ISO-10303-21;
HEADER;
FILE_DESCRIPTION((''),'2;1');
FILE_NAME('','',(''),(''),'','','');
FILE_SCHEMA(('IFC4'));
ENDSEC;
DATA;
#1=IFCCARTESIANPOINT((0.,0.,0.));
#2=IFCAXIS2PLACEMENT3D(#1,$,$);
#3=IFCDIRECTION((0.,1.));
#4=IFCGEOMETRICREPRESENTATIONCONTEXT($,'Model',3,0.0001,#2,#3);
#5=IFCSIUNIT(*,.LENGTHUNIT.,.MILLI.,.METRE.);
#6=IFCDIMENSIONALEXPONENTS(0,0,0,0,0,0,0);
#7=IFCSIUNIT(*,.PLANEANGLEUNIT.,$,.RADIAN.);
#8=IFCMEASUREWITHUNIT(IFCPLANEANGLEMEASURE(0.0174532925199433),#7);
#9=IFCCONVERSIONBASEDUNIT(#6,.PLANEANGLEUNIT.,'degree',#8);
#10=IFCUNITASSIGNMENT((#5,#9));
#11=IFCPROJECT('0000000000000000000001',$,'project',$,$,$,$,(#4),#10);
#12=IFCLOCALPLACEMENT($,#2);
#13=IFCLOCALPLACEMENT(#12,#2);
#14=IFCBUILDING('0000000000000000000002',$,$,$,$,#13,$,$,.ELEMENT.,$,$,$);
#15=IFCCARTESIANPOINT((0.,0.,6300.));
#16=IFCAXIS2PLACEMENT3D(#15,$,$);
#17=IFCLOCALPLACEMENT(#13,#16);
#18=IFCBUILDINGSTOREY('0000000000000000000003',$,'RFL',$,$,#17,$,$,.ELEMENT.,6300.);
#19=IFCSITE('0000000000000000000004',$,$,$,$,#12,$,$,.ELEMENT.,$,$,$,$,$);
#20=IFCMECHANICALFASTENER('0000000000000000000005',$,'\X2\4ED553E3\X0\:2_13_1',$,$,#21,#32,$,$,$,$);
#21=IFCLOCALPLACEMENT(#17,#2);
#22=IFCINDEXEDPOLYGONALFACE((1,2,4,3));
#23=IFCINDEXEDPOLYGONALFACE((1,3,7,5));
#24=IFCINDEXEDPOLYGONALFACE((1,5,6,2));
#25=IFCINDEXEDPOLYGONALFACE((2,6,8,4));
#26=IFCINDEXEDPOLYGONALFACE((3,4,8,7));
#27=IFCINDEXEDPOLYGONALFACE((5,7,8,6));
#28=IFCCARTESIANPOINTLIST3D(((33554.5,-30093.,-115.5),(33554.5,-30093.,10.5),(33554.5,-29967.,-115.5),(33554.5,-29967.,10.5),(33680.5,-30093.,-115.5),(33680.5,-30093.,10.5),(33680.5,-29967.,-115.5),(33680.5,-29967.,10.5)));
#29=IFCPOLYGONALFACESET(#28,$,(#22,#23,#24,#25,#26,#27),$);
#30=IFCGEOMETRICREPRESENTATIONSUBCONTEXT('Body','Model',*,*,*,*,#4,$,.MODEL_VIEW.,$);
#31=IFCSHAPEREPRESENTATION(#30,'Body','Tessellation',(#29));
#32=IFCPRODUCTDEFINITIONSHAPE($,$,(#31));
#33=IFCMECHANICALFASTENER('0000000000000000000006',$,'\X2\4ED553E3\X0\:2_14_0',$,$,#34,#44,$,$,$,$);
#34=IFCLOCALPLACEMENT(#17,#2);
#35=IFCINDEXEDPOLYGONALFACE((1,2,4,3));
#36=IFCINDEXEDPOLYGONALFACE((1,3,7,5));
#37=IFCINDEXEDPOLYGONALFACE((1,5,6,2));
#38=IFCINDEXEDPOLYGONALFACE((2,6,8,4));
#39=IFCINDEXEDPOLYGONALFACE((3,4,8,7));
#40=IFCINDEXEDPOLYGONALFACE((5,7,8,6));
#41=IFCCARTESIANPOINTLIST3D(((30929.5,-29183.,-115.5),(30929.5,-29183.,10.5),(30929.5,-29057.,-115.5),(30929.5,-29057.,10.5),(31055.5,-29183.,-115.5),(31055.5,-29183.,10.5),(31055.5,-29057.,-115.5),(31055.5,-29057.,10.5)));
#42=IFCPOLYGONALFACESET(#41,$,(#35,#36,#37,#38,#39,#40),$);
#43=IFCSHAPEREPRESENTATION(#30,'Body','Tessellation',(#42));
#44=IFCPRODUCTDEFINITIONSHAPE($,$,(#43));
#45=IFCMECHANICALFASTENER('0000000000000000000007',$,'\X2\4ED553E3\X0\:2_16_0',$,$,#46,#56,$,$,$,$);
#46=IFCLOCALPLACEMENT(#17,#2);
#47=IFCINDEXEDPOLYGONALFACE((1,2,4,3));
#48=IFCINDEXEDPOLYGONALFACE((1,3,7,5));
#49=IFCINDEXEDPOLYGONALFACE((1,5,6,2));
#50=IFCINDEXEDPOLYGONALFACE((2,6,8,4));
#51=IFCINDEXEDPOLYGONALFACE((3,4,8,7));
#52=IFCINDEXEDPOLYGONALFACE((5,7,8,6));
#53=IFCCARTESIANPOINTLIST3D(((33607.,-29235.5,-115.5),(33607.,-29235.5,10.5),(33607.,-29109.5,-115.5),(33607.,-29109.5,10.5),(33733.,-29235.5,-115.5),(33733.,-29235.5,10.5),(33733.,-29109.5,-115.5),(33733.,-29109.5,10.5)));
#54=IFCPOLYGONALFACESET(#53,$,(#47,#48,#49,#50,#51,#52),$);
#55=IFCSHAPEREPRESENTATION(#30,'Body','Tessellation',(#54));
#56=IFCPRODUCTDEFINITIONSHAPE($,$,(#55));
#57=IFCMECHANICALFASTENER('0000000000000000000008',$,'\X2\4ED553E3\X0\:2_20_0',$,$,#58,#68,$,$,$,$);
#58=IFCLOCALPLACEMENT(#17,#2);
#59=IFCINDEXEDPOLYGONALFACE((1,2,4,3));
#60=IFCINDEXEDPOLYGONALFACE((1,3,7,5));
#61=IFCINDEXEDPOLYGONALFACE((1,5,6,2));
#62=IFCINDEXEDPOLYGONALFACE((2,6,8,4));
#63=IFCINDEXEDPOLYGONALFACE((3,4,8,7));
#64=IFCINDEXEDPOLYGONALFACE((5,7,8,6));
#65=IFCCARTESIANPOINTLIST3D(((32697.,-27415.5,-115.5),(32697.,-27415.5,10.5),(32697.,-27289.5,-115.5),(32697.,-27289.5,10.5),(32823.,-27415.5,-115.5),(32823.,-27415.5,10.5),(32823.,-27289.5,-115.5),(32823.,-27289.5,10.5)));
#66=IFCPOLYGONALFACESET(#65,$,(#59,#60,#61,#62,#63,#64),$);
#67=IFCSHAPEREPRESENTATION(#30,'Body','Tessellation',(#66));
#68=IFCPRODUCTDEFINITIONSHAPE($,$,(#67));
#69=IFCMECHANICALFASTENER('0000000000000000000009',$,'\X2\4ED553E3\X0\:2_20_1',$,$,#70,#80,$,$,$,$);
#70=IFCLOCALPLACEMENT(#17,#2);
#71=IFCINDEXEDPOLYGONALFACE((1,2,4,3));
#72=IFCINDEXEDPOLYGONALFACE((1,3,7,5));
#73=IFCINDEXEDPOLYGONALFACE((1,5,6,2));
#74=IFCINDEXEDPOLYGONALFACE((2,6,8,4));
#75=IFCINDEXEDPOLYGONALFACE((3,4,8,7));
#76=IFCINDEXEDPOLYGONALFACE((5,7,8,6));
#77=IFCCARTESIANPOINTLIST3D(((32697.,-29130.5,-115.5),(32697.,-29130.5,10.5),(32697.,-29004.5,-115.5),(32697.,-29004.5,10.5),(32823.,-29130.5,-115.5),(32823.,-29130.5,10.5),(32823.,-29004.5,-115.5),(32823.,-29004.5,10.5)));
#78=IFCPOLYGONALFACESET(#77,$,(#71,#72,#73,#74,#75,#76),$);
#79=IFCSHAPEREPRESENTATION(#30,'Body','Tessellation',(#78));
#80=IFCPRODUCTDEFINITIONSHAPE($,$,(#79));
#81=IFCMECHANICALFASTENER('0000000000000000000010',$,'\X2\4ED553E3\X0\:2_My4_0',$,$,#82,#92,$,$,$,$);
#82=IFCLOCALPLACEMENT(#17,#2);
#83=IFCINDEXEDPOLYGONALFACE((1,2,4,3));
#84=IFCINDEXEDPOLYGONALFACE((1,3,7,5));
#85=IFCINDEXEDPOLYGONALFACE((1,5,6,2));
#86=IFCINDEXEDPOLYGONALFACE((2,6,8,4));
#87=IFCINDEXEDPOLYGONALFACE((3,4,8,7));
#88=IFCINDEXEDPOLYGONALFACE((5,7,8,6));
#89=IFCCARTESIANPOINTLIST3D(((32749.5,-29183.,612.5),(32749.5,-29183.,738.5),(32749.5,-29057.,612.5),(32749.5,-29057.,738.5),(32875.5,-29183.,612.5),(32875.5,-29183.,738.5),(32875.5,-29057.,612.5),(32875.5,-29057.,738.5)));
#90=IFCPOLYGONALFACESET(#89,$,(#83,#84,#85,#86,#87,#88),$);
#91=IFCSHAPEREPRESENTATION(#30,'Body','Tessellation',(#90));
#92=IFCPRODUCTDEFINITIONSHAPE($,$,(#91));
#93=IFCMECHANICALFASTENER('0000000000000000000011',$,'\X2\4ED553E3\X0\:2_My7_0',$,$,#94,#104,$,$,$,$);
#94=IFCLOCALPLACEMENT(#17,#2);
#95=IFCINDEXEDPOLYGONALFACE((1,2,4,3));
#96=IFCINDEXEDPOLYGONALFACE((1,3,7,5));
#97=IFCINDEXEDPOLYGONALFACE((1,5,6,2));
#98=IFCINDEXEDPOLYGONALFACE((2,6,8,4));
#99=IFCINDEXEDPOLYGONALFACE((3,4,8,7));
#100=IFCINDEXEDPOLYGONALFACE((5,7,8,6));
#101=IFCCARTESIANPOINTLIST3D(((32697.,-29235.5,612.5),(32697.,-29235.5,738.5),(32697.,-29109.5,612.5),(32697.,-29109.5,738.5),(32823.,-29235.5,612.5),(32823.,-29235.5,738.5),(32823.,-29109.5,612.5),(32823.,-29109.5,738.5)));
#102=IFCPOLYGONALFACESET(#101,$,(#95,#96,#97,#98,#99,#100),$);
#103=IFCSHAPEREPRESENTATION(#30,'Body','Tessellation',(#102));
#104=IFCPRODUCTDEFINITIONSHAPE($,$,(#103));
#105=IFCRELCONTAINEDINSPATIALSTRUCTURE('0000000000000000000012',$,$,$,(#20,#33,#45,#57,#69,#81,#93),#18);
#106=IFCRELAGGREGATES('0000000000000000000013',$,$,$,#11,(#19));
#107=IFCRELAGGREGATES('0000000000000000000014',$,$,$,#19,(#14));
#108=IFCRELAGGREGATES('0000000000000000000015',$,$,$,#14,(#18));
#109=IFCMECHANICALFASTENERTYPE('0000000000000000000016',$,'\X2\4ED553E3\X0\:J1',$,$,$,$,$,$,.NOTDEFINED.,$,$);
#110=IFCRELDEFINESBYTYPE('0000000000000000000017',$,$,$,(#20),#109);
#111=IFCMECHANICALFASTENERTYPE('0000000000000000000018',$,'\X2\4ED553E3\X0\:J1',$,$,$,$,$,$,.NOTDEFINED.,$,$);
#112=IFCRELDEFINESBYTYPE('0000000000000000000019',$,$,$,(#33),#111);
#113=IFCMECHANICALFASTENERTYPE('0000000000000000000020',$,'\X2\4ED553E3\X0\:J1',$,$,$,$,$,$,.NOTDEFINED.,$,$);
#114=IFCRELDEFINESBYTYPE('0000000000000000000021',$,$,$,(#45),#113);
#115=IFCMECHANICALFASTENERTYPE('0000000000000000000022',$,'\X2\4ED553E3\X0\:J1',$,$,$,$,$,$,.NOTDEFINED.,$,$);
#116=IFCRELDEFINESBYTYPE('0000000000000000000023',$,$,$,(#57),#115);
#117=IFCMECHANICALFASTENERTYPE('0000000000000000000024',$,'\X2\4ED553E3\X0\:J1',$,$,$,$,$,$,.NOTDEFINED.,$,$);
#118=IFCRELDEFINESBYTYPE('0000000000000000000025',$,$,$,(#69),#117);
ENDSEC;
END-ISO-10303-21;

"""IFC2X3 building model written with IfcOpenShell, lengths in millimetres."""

from ifc_helpers import new_model, entity, si_unit, converted_unit, direction, frame, origin, origin_with_axes, origin_2d, place, context, subcontext, project, spatial, rectangle, extrude, type_object, element, save


model = new_model("IFC2X3")

# Units and contexts
model_context = context("Model", 3, precision=0.0001, world=origin(), true_north=direction((0.0, 1.0)))
body_context = subcontext(model_context, "Body", "Model", "MODEL_VIEW")
ifc_project = project(units=[si_unit("LENGTHUNIT", "METRE", prefix="MILLI"), converted_unit("PLANEANGLEUNIT", "degree", entity("IfcPlaneAngleMeasure", 0.0174532925199433), si_unit("PLANEANGLEUNIT", "RADIAN"), dimensions=[0, 0, 0, 0, 0, 0, 0])], contexts=[model_context])

# Site, building, storey
site_placement = place(None, origin())
site = spatial("IfcSite", under=ifc_project, at=site_placement, CompositionType="ELEMENT")
building_placement = place(site_placement, origin())
building = spatial("IfcBuilding", under=site, at=building_placement, CompositionType="ELEMENT")
storey_placement = place(building_placement, frame((0.0, 0.0, 6300.0)))
storey = spatial("IfcBuildingStorey", under=building, at=storey_placement, Name="RFL", CompositionType="ELEMENT", Elevation=6300.0)

# Mechanical fasteners
mechanical_fastener_type_1 = type_object("IfcMechanicalFastenerType", Name="仕口:J1")
mechanical_fastener_1_placement = place(storey_placement, frame((33617.5, -30030.0, -115.5)))
element("IfcMechanicalFastener", 1, at=mechanical_fastener_1_placement, inside=storey, type_object=mechanical_fastener_type_1, Name="仕口:2_13_1", context=body_context, shape_type="SweptSolid", body=[
    extrude(rectangle(XDim=126.0, YDim=126.0, at=origin_2d()), origin_with_axes(), (0.0, 0.0, 1.0), 126.0),
])
mechanical_fastener_type_2 = type_object("IfcMechanicalFastenerType", Name="仕口:J1")
mechanical_fastener_2_placement = place(storey_placement, frame((30992.5, -29120.0, -115.5)))
element("IfcMechanicalFastener", 2, at=mechanical_fastener_2_placement, inside=storey, type_object=mechanical_fastener_type_2, Name="仕口:2_14_0", context=body_context, shape_type="SweptSolid", body=[
    extrude(rectangle(XDim=126.0, YDim=126.0, at=origin_2d()), origin_with_axes(), (0.0, 0.0, 1.0), 126.0),
])
mechanical_fastener_type_3 = type_object("IfcMechanicalFastenerType", Name="仕口:J1")
mechanical_fastener_3_placement = place(storey_placement, frame((33670.0, -29172.5, -115.5)))
element("IfcMechanicalFastener", 3, at=mechanical_fastener_3_placement, inside=storey, type_object=mechanical_fastener_type_3, Name="仕口:2_16_0", context=body_context, shape_type="SweptSolid", body=[
    extrude(rectangle(XDim=126.0, YDim=126.0, at=origin_2d()), origin_with_axes(), (0.0, 0.0, 1.0), 126.0),
])
mechanical_fastener_type_4 = type_object("IfcMechanicalFastenerType", Name="仕口:J1")
mechanical_fastener_4_placement = place(storey_placement, frame((32760.0, -27352.5, -115.5)))
element("IfcMechanicalFastener", 4, at=mechanical_fastener_4_placement, inside=storey, type_object=mechanical_fastener_type_4, Name="仕口:2_20_0", context=body_context, shape_type="SweptSolid", body=[
    extrude(rectangle(XDim=126.0, YDim=126.0, at=origin_2d()), origin_with_axes(), (0.0, 0.0, 1.0), 126.0),
])
mechanical_fastener_type_5 = type_object("IfcMechanicalFastenerType", Name="仕口:J1")
mechanical_fastener_5_placement = place(storey_placement, frame((32760.0, -29067.5, -115.5)))
element("IfcMechanicalFastener", 5, at=mechanical_fastener_5_placement, inside=storey, type_object=mechanical_fastener_type_5, Name="仕口:2_20_1", context=body_context, shape_type="SweptSolid", body=[
    extrude(rectangle(XDim=126.0, YDim=126.0, at=origin_2d()), origin_with_axes(), (0.0, 0.0, 1.0), 126.0),
])
for number, where, name in (
    (6, (32812.5, -29120.0, 612.5), "仕口:2_My4_0"),
    (7, (32760.0, -29172.5, 612.5), "仕口:2_My7_0"),
):
    element("IfcMechanicalFastener", number, at=place(storey_placement, frame(where)), inside=storey, Name=name, context=body_context, shape_type="SweptSolid", body=[
        extrude(rectangle(XDim=126.0, YDim=126.0, at=origin_2d()), origin_with_axes(), (0.0, 0.0, 1.0), 126.0),
    ])

save(model, "model.ifc")
